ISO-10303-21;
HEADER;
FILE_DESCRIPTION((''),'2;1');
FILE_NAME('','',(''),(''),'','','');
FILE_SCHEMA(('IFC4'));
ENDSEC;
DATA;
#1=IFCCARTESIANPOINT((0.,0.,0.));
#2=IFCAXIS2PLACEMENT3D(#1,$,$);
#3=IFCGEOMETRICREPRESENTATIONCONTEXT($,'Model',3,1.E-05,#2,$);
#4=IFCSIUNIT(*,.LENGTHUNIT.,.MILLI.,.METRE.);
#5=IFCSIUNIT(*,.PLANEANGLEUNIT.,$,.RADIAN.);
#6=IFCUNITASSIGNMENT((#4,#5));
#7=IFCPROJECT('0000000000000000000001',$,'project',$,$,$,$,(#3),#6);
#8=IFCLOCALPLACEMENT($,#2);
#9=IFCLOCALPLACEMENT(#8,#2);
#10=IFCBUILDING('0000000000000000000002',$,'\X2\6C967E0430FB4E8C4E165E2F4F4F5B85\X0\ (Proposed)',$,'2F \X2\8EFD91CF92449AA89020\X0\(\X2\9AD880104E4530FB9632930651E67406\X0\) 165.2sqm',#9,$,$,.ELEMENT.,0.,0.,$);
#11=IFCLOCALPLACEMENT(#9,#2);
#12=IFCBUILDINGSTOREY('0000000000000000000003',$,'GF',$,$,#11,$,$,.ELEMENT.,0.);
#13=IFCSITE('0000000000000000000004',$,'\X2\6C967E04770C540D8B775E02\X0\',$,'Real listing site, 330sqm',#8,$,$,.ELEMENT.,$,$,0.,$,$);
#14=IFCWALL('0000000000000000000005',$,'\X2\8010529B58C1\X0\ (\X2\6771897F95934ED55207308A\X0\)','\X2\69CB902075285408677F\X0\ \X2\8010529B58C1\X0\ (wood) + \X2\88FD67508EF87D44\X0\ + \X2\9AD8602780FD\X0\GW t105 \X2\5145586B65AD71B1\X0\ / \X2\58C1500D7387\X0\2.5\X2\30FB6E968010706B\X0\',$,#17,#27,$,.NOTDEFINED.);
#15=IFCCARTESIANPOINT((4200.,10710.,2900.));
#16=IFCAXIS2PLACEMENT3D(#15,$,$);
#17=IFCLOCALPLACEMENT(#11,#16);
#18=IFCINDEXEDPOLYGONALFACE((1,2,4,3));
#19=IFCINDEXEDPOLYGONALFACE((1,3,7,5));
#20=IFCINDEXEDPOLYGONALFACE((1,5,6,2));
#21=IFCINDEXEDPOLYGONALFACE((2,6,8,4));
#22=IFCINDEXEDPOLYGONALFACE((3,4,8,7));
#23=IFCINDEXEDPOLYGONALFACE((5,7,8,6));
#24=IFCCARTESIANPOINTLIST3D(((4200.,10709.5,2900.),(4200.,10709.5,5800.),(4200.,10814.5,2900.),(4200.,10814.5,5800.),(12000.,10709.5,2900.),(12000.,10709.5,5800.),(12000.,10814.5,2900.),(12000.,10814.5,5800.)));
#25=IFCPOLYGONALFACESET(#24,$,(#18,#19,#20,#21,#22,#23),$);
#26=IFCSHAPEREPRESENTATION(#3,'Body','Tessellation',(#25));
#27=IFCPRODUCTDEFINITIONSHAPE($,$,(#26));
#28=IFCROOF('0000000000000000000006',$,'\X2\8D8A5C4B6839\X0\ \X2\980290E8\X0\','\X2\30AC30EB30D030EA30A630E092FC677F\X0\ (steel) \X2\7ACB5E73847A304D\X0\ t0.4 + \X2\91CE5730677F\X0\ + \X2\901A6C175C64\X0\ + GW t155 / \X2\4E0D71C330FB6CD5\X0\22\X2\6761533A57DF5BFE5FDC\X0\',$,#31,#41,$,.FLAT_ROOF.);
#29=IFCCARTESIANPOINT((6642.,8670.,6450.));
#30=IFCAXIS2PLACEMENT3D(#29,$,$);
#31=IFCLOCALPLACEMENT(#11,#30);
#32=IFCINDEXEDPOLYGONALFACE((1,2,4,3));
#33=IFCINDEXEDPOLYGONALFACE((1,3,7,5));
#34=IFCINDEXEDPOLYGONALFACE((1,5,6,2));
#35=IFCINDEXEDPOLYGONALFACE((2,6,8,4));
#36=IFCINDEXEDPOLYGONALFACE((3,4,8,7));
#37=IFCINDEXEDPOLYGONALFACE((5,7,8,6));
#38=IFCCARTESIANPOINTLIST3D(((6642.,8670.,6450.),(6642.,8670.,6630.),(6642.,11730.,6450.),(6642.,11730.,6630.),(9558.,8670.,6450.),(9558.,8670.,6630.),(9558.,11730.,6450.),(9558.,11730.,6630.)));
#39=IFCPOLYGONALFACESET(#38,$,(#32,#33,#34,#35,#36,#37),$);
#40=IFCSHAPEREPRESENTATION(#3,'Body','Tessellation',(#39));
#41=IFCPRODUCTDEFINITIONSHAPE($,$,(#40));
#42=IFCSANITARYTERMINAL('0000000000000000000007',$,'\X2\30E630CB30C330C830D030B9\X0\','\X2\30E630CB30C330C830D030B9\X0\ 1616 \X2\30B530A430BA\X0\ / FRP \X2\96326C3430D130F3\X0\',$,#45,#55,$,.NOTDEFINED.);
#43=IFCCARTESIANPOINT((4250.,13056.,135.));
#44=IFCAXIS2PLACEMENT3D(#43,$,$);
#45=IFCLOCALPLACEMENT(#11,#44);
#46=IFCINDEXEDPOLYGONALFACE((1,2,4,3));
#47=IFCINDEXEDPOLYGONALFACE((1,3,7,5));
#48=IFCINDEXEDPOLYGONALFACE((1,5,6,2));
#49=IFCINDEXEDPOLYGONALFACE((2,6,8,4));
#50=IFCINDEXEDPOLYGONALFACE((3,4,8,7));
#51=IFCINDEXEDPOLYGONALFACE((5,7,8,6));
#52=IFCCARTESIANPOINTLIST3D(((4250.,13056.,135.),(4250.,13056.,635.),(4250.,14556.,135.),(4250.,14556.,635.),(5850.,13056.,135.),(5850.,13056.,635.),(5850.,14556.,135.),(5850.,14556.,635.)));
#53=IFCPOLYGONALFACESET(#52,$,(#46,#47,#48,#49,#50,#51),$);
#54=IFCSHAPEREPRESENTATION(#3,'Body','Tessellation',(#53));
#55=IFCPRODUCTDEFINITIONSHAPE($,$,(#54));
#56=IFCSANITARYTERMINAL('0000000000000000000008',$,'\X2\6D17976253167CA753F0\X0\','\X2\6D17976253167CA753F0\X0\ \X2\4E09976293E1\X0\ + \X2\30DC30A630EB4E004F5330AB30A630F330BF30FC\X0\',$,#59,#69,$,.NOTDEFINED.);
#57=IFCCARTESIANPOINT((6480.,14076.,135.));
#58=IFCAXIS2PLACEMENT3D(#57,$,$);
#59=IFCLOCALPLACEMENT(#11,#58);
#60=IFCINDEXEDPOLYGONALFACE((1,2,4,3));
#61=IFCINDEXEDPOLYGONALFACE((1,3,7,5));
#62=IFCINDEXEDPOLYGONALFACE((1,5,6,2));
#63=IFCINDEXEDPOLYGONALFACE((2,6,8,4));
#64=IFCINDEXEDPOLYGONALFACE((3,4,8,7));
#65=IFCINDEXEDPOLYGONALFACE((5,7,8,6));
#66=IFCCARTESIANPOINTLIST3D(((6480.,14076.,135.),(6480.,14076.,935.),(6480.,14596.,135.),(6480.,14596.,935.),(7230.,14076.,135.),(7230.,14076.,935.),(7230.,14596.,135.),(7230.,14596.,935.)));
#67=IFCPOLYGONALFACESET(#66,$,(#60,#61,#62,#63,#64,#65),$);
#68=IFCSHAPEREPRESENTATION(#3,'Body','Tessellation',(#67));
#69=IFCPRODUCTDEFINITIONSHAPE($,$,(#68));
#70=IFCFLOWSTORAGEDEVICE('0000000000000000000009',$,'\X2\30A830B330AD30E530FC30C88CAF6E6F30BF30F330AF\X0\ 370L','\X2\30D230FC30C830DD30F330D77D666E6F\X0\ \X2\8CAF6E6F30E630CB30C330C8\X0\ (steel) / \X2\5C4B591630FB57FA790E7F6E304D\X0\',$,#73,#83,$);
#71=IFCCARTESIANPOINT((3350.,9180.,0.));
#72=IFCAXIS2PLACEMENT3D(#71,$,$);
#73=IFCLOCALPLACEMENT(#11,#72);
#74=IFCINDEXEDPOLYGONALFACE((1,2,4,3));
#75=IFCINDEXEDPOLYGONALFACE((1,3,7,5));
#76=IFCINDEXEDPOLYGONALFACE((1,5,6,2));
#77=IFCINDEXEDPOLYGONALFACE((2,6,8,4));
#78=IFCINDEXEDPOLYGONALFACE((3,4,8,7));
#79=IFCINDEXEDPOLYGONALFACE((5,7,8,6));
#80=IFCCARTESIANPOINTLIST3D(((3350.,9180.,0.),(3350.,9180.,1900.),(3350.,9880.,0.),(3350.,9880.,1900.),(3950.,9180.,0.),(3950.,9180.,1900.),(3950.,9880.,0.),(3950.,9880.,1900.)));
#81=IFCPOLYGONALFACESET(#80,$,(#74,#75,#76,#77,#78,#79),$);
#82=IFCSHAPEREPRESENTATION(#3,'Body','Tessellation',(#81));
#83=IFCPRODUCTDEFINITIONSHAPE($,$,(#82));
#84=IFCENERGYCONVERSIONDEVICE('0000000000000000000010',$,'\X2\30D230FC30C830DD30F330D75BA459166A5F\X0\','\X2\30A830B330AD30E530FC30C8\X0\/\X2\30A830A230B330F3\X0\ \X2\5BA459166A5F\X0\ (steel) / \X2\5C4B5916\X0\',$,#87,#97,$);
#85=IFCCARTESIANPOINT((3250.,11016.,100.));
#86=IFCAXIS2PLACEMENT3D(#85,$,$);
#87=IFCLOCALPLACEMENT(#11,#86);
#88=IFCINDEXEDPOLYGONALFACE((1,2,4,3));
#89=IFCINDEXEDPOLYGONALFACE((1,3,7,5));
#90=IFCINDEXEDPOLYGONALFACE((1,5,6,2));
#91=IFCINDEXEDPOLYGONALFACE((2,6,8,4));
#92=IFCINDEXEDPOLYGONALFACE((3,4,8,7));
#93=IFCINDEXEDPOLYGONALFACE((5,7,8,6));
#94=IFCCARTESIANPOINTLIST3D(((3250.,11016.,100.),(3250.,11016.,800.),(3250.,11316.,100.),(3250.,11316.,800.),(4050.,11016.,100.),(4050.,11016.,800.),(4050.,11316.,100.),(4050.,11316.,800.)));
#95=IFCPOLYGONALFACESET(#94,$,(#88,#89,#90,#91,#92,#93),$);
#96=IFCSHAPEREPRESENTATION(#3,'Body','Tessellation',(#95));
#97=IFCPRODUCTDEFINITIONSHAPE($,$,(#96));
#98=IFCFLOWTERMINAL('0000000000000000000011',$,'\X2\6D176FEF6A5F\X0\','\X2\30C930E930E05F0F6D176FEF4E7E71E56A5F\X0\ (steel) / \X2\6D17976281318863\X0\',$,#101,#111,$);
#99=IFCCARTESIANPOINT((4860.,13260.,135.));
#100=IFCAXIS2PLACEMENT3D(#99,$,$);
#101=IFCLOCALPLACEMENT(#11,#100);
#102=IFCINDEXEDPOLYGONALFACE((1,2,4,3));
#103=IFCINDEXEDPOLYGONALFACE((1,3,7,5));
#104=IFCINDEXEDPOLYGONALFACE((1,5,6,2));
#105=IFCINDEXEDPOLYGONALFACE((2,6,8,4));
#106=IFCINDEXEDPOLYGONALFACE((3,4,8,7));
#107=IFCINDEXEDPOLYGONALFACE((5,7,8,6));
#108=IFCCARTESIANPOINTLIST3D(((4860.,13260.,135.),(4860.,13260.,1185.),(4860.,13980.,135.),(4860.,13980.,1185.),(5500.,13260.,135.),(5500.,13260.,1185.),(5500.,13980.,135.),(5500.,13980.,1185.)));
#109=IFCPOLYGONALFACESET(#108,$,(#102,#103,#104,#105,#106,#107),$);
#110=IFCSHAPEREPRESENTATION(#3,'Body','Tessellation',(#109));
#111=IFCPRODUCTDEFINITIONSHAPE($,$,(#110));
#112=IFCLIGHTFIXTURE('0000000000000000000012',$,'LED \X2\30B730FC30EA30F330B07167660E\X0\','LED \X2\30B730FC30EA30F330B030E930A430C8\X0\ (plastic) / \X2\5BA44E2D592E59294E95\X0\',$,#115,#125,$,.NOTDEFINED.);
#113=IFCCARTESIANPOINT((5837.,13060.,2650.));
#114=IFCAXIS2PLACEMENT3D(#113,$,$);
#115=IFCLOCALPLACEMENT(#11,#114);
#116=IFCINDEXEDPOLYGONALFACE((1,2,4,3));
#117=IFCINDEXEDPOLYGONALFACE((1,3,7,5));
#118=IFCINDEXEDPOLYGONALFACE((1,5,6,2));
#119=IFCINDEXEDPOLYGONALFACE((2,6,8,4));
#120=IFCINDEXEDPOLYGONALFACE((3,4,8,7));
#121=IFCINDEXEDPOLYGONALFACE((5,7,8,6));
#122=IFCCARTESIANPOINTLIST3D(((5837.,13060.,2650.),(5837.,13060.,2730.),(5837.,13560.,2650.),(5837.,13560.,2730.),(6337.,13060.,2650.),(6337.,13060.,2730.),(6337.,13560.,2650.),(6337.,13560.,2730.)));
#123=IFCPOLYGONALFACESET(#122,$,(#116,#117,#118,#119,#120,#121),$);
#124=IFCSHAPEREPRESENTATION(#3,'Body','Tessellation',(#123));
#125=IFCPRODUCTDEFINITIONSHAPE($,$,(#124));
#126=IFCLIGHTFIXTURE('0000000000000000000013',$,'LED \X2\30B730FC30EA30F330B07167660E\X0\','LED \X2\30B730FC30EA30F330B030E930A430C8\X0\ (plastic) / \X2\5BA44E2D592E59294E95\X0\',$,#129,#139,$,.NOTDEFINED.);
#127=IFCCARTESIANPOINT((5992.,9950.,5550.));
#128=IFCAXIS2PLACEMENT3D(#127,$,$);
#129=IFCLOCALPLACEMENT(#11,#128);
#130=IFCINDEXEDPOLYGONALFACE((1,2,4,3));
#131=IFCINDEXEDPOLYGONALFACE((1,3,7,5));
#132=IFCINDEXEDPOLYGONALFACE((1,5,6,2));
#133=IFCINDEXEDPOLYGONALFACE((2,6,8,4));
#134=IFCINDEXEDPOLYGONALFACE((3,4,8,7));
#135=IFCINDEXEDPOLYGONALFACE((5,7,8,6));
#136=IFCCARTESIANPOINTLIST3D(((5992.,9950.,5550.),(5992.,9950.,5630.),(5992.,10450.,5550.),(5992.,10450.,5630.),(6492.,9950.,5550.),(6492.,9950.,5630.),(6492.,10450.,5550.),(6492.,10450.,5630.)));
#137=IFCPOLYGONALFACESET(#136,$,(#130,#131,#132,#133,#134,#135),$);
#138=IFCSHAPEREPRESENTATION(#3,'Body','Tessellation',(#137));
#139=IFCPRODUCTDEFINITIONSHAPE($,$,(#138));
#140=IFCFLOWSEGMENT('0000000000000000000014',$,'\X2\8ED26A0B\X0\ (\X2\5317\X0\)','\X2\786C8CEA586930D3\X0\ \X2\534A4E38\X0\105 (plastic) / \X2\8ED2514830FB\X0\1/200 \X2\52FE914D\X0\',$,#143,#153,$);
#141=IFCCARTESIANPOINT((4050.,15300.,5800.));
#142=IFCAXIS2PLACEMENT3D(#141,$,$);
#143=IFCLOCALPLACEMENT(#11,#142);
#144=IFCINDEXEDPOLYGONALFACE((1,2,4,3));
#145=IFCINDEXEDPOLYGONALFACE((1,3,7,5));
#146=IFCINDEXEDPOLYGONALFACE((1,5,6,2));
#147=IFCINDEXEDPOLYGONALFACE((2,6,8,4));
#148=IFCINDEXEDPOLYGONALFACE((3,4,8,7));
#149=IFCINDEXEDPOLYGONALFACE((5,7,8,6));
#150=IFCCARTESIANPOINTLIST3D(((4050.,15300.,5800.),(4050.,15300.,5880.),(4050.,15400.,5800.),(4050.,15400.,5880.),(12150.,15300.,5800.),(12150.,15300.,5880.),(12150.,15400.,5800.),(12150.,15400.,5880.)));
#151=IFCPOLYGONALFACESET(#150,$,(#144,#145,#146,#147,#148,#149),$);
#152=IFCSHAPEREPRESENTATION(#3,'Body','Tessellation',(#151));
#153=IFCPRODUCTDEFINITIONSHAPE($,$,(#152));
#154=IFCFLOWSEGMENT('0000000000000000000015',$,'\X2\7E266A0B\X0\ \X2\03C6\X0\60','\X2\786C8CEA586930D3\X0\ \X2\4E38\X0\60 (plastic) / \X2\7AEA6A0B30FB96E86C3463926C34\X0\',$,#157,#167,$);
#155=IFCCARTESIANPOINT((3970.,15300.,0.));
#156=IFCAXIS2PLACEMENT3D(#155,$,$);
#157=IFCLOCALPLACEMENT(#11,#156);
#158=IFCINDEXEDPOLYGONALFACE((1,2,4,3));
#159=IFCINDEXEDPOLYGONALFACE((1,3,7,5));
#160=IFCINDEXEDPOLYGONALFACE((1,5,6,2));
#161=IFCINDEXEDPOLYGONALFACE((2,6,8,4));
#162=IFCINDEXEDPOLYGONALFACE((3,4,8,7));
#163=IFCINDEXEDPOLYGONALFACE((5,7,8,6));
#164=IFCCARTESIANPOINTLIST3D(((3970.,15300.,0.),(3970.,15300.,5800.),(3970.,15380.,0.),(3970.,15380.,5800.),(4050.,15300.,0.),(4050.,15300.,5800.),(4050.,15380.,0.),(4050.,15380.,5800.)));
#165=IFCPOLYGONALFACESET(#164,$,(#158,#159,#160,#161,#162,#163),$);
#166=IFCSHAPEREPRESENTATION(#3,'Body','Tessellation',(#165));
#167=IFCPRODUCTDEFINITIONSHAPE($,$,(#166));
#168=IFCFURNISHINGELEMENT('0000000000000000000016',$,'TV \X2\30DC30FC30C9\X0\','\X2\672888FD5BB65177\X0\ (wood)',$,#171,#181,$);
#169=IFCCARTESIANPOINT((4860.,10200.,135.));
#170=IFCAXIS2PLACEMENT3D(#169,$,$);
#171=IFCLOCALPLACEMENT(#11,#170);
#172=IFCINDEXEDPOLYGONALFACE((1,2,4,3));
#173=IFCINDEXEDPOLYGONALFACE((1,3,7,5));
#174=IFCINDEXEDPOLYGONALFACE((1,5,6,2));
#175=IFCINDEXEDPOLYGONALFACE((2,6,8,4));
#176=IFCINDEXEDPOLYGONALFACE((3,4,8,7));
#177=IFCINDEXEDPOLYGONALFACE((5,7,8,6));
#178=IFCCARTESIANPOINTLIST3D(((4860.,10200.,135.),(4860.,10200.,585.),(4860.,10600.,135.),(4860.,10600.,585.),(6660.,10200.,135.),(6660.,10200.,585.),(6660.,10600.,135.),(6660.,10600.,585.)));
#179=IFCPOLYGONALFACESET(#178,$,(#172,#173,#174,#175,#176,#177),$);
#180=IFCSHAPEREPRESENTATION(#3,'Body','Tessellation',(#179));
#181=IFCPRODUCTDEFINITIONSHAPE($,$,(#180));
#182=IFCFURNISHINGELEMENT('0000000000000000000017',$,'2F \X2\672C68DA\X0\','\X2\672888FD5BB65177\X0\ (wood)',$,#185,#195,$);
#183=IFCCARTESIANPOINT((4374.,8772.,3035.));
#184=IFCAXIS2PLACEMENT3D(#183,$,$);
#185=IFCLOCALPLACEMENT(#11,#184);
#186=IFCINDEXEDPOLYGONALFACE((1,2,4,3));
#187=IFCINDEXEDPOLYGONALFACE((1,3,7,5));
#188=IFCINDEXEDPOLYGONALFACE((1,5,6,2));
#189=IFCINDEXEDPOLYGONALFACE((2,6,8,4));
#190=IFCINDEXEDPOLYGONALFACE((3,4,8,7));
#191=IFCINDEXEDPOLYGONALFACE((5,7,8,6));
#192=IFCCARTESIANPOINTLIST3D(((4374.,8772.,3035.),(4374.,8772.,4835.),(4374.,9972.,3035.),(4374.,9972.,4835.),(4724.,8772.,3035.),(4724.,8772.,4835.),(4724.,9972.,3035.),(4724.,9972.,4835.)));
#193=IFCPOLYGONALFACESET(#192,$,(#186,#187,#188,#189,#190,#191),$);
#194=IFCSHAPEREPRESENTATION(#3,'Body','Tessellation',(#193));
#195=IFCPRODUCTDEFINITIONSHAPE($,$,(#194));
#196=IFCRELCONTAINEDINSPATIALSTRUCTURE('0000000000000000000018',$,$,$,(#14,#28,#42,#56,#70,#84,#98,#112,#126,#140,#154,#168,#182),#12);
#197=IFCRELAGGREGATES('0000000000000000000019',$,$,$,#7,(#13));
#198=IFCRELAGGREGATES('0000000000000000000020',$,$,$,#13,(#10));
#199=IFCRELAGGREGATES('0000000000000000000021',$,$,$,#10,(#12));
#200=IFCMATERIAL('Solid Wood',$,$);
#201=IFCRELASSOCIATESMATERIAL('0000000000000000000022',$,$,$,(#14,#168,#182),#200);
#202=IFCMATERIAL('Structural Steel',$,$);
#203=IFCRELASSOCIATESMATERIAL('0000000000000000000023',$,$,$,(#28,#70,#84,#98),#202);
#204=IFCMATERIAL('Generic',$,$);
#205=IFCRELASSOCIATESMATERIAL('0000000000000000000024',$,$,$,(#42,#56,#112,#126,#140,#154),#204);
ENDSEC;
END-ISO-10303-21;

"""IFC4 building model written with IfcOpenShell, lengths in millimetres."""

from ifc_helpers import new_model, si_unit, frame, frame_2d, origin, place, context, project, spatial, rectangle, extrude, material, element, save


model = new_model("IFC4")

# Units and contexts
model_context = context("Model", 3, precision=1e-05, world=origin())
ifc_project = project(units=[si_unit("LENGTHUNIT", "METRE", prefix="MILLI"), si_unit("PLANEANGLEUNIT", "RADIAN")], contexts=[model_context])

# Site, building, storey
site_placement = place(None, origin())
site = spatial("IfcSite", under=ifc_project, at=site_placement, Name="沖縄県名護市", ObjectType="Real listing site, 330sqm", CompositionType="ELEMENT", RefElevation=0.0)
building_placement = place(site_placement, origin())
building = spatial("IfcBuilding", under=site, at=building_placement, Name="沖縄・二世帯住宅 (Proposed)", ObjectType="2F 軽量鉄骨造(高耐久・防錆処理) 165.2sqm", CompositionType="ELEMENT", ElevationOfRefHeight=0.0, ElevationOfTerrain=0.0)
storey_placement = place(building_placement, origin())
storey = spatial("IfcBuildingStorey", under=building, at=storey_placement, Name="GF", CompositionType="ELEMENT", Elevation=0.0)

# Shared definitions
ifc_material_1 = material(Name="Solid Wood")

# Wall
wall_1_placement = place(storey_placement, frame((4200.0, 10710.0, 2900.0)))
element("IfcWall", 1, at=wall_1_placement, inside=storey, material=ifc_material_1, Name="耐力壁 (東西間仕切り)", Description="構造用合板 耐力壁 (wood) + 製材軸組 + 高性能GW t105 充填断熱 / 壁倍率2.5・準耐火", PredefinedType="NOTDEFINED", context=model_context, shape_type="SweptSolid", body=[
    extrude(rectangle(XDim=7800.0, YDim=105.0, at=frame_2d((3900.0, 52.0))), frame((4200.0, 10710.0, 2900.0)), (0.0, 0.0, 1.0), 2900.0),
])

# Roof
ifc_material_2 = material(Name="Structural Steel")
roof_placement = place(storey_placement, frame((6642.0, 8670.0, 6450.0)))
element("IfcRoof", 2, at=roof_placement, inside=storey, material=ifc_material_2, Name="越屋根 頂部", Description="ガルバリウム鋼板 (steel) 立平葺き t0.4 + 野地板 + 通気層 + GW t155 / 不燃・法22条区域対応", PredefinedType="FLAT_ROOF", context=model_context, shape_type="SweptSolid", body=[
    extrude(rectangle(XDim=2916.0, YDim=3060.0, at=frame_2d((1458.0, 1530.0))), frame((6642.0, 8670.0, 6450.0)), (0.0, 0.0, 1.0), 180.0),
])

# Sanitary terminals
ifc_material_3 = material(Name="Generic")
sanitary_terminal_1_placement = place(storey_placement, frame((4250.0, 13056.0, 135.0)))
element("IfcSanitaryTerminal", 3, at=sanitary_terminal_1_placement, inside=storey, material=ifc_material_3, Name="ユニットバス", Description="ユニットバス 1616 サイズ / FRP 防水パン", PredefinedType="NOTDEFINED", context=model_context, shape_type="SweptSolid", body=[
    extrude(rectangle(XDim=1600.0, YDim=1500.0, at=frame_2d((800.0, 750.0))), frame((4250.0, 13056.0, 135.0)), (0.0, 0.0, 1.0), 500.0),
])
sanitary_terminal_2_placement = place(storey_placement, frame((6480.0, 14076.0, 135.0)))
element("IfcSanitaryTerminal", 4, at=sanitary_terminal_2_placement, inside=storey, material=ifc_material_3, Name="洗面化粧台", Description="洗面化粧台 三面鏡 + ボウル一体カウンター", PredefinedType="NOTDEFINED", context=model_context, shape_type="SweptSolid", body=[
    extrude(rectangle(XDim=750.0, YDim=520.0, at=frame_2d((375.0, 260.0))), frame((6480.0, 14076.0, 135.0)), (0.0, 0.0, 1.0), 800.0),
])

# Flow storage device
flow_storage_device_placement = place(storey_placement, frame((3350.0, 9180.0, 0.0)))
element("IfcFlowStorageDevice", 5, at=flow_storage_device_placement, inside=storey, material=ifc_material_2, Name="エコキュート貯湯タンク 370L", Description="ヒートポンプ給湯 貯湯ユニット (steel) / 屋外・基礎置き", context=model_context, shape_type="SweptSolid", body=[
    extrude(rectangle(XDim=600.0, YDim=700.0, at=frame_2d((300.0, 350.0))), frame((3350.0, 9180.0, 0.0)), (0.0, 0.0, 1.0), 1900.0),
])

# Energy conversion device
energy_conversion_device_placement = place(storey_placement, frame((3250.0, 11016.0, 100.0)))
element("IfcEnergyConversionDevice", 6, at=energy_conversion_device_placement, inside=storey, material=ifc_material_2, Name="ヒートポンプ室外機", Description="エコキュート/エアコン 室外機 (steel) / 屋外", context=model_context, shape_type="SweptSolid", body=[
    extrude(rectangle(XDim=800.0, YDim=300.0, at=frame_2d((400.0, 150.0))), frame((3250.0, 11016.0, 100.0)), (0.0, 0.0, 1.0), 700.0),
])

# Flow terminal
flow_terminal_placement = place(storey_placement, frame((4860.0, 13260.0, 135.0)))
element("IfcFlowTerminal", 7, at=flow_terminal_placement, inside=storey, material=ifc_material_2, Name="洗濯機", Description="ドラム式洗濯乾燥機 (steel) / 洗面脱衣", context=model_context, shape_type="SweptSolid", body=[
    extrude(rectangle(XDim=640.0, YDim=720.0, at=frame_2d((320.0, 360.0))), frame((4860.0, 13260.0, 135.0)), (0.0, 0.0, 1.0), 1050.0),
])

# Light fixtures
light_fixture_1_placement = place(storey_placement, frame((5837.0, 13060.0, 2650.0)))
element("IfcLightFixture", 8, at=light_fixture_1_placement, inside=storey, material=ifc_material_3, Name="LED シーリング照明", Description="LED シーリングライト (plastic) / 室中央天井", PredefinedType="NOTDEFINED", context=model_context, shape_type="SweptSolid", body=[
    extrude(rectangle(XDim=500.0, YDim=500.0, at=frame_2d((250.0, 250.0))), frame((5837.0, 13060.0, 2650.0)), (0.0, 0.0, 1.0), 80.0),
])
light_fixture_2_placement = place(storey_placement, frame((5992.0, 9950.0, 5550.0)))
element("IfcLightFixture", 9, at=light_fixture_2_placement, inside=storey, material=ifc_material_3, Name="LED シーリング照明", Description="LED シーリングライト (plastic) / 室中央天井", PredefinedType="NOTDEFINED", context=model_context, shape_type="SweptSolid", body=[
    extrude(rectangle(XDim=500.0, YDim=500.0, at=frame_2d((250.0, 250.0))), frame((5992.0, 9950.0, 5550.0)), (0.0, 0.0, 1.0), 80.0),
])

# Flow segments
flow_segment_1_placement = place(storey_placement, frame((4050.0, 15300.0, 5800.0)))
element("IfcFlowSegment", 10, at=flow_segment_1_placement, inside=storey, material=ifc_material_3, Name="軒樋 (北)", Description="硬質塩ビ 半丸105 (plastic) / 軒先・1/200 勾配", context=model_context, shape_type="SweptSolid", body=[
    extrude(rectangle(XDim=8100.0, YDim=100.0, at=frame_2d((4050.0, 50.0))), frame((4050.0, 15300.0, 5800.0)), (0.0, 0.0, 1.0), 80.0),
])
flow_segment_2_placement = place(storey_placement, frame((3970.0, 15300.0, 0.0)))
element("IfcFlowSegment", 11, at=flow_segment_2_placement, inside=storey, material=ifc_material_3, Name="縦樋 φ60", Description="硬質塩ビ 丸60 (plastic) / 竪樋・雨水排水", context=model_context, shape_type="SweptSolid", body=[
    extrude(rectangle(XDim=80.0, YDim=80.0, at=frame_2d((40.0, 40.0))), frame((3970.0, 15300.0, 0.0)), (0.0, 0.0, 1.0), 5800.0),
])

# Furnishing elements
furnishing_1_placement = place(storey_placement, frame((4860.0, 10200.0, 135.0)))
element("IfcFurnishingElement", 12, at=furnishing_1_placement, inside=storey, material=ifc_material_1, Name="TV ボード", Description="木製家具 (wood)", context=model_context, shape_type="SweptSolid", body=[
    extrude(rectangle(XDim=1800.0, YDim=400.0, at=frame_2d((900.0, 200.0))), frame((4860.0, 10200.0, 135.0)), (0.0, 0.0, 1.0), 450.0),
])
furnishing_2_placement = place(storey_placement, frame((4374.0, 8772.0, 3035.0)))
element("IfcFurnishingElement", 13, at=furnishing_2_placement, inside=storey, material=ifc_material_1, Name="2F 本棚", Description="木製家具 (wood)", context=model_context, shape_type="SweptSolid", body=[
    extrude(rectangle(XDim=350.0, YDim=1200.0, at=frame_2d((175.0, 600.0))), frame((4374.0, 8772.0, 3035.0)), (0.0, 0.0, 1.0), 1800.0),
])

save(model, "model.ifc")
